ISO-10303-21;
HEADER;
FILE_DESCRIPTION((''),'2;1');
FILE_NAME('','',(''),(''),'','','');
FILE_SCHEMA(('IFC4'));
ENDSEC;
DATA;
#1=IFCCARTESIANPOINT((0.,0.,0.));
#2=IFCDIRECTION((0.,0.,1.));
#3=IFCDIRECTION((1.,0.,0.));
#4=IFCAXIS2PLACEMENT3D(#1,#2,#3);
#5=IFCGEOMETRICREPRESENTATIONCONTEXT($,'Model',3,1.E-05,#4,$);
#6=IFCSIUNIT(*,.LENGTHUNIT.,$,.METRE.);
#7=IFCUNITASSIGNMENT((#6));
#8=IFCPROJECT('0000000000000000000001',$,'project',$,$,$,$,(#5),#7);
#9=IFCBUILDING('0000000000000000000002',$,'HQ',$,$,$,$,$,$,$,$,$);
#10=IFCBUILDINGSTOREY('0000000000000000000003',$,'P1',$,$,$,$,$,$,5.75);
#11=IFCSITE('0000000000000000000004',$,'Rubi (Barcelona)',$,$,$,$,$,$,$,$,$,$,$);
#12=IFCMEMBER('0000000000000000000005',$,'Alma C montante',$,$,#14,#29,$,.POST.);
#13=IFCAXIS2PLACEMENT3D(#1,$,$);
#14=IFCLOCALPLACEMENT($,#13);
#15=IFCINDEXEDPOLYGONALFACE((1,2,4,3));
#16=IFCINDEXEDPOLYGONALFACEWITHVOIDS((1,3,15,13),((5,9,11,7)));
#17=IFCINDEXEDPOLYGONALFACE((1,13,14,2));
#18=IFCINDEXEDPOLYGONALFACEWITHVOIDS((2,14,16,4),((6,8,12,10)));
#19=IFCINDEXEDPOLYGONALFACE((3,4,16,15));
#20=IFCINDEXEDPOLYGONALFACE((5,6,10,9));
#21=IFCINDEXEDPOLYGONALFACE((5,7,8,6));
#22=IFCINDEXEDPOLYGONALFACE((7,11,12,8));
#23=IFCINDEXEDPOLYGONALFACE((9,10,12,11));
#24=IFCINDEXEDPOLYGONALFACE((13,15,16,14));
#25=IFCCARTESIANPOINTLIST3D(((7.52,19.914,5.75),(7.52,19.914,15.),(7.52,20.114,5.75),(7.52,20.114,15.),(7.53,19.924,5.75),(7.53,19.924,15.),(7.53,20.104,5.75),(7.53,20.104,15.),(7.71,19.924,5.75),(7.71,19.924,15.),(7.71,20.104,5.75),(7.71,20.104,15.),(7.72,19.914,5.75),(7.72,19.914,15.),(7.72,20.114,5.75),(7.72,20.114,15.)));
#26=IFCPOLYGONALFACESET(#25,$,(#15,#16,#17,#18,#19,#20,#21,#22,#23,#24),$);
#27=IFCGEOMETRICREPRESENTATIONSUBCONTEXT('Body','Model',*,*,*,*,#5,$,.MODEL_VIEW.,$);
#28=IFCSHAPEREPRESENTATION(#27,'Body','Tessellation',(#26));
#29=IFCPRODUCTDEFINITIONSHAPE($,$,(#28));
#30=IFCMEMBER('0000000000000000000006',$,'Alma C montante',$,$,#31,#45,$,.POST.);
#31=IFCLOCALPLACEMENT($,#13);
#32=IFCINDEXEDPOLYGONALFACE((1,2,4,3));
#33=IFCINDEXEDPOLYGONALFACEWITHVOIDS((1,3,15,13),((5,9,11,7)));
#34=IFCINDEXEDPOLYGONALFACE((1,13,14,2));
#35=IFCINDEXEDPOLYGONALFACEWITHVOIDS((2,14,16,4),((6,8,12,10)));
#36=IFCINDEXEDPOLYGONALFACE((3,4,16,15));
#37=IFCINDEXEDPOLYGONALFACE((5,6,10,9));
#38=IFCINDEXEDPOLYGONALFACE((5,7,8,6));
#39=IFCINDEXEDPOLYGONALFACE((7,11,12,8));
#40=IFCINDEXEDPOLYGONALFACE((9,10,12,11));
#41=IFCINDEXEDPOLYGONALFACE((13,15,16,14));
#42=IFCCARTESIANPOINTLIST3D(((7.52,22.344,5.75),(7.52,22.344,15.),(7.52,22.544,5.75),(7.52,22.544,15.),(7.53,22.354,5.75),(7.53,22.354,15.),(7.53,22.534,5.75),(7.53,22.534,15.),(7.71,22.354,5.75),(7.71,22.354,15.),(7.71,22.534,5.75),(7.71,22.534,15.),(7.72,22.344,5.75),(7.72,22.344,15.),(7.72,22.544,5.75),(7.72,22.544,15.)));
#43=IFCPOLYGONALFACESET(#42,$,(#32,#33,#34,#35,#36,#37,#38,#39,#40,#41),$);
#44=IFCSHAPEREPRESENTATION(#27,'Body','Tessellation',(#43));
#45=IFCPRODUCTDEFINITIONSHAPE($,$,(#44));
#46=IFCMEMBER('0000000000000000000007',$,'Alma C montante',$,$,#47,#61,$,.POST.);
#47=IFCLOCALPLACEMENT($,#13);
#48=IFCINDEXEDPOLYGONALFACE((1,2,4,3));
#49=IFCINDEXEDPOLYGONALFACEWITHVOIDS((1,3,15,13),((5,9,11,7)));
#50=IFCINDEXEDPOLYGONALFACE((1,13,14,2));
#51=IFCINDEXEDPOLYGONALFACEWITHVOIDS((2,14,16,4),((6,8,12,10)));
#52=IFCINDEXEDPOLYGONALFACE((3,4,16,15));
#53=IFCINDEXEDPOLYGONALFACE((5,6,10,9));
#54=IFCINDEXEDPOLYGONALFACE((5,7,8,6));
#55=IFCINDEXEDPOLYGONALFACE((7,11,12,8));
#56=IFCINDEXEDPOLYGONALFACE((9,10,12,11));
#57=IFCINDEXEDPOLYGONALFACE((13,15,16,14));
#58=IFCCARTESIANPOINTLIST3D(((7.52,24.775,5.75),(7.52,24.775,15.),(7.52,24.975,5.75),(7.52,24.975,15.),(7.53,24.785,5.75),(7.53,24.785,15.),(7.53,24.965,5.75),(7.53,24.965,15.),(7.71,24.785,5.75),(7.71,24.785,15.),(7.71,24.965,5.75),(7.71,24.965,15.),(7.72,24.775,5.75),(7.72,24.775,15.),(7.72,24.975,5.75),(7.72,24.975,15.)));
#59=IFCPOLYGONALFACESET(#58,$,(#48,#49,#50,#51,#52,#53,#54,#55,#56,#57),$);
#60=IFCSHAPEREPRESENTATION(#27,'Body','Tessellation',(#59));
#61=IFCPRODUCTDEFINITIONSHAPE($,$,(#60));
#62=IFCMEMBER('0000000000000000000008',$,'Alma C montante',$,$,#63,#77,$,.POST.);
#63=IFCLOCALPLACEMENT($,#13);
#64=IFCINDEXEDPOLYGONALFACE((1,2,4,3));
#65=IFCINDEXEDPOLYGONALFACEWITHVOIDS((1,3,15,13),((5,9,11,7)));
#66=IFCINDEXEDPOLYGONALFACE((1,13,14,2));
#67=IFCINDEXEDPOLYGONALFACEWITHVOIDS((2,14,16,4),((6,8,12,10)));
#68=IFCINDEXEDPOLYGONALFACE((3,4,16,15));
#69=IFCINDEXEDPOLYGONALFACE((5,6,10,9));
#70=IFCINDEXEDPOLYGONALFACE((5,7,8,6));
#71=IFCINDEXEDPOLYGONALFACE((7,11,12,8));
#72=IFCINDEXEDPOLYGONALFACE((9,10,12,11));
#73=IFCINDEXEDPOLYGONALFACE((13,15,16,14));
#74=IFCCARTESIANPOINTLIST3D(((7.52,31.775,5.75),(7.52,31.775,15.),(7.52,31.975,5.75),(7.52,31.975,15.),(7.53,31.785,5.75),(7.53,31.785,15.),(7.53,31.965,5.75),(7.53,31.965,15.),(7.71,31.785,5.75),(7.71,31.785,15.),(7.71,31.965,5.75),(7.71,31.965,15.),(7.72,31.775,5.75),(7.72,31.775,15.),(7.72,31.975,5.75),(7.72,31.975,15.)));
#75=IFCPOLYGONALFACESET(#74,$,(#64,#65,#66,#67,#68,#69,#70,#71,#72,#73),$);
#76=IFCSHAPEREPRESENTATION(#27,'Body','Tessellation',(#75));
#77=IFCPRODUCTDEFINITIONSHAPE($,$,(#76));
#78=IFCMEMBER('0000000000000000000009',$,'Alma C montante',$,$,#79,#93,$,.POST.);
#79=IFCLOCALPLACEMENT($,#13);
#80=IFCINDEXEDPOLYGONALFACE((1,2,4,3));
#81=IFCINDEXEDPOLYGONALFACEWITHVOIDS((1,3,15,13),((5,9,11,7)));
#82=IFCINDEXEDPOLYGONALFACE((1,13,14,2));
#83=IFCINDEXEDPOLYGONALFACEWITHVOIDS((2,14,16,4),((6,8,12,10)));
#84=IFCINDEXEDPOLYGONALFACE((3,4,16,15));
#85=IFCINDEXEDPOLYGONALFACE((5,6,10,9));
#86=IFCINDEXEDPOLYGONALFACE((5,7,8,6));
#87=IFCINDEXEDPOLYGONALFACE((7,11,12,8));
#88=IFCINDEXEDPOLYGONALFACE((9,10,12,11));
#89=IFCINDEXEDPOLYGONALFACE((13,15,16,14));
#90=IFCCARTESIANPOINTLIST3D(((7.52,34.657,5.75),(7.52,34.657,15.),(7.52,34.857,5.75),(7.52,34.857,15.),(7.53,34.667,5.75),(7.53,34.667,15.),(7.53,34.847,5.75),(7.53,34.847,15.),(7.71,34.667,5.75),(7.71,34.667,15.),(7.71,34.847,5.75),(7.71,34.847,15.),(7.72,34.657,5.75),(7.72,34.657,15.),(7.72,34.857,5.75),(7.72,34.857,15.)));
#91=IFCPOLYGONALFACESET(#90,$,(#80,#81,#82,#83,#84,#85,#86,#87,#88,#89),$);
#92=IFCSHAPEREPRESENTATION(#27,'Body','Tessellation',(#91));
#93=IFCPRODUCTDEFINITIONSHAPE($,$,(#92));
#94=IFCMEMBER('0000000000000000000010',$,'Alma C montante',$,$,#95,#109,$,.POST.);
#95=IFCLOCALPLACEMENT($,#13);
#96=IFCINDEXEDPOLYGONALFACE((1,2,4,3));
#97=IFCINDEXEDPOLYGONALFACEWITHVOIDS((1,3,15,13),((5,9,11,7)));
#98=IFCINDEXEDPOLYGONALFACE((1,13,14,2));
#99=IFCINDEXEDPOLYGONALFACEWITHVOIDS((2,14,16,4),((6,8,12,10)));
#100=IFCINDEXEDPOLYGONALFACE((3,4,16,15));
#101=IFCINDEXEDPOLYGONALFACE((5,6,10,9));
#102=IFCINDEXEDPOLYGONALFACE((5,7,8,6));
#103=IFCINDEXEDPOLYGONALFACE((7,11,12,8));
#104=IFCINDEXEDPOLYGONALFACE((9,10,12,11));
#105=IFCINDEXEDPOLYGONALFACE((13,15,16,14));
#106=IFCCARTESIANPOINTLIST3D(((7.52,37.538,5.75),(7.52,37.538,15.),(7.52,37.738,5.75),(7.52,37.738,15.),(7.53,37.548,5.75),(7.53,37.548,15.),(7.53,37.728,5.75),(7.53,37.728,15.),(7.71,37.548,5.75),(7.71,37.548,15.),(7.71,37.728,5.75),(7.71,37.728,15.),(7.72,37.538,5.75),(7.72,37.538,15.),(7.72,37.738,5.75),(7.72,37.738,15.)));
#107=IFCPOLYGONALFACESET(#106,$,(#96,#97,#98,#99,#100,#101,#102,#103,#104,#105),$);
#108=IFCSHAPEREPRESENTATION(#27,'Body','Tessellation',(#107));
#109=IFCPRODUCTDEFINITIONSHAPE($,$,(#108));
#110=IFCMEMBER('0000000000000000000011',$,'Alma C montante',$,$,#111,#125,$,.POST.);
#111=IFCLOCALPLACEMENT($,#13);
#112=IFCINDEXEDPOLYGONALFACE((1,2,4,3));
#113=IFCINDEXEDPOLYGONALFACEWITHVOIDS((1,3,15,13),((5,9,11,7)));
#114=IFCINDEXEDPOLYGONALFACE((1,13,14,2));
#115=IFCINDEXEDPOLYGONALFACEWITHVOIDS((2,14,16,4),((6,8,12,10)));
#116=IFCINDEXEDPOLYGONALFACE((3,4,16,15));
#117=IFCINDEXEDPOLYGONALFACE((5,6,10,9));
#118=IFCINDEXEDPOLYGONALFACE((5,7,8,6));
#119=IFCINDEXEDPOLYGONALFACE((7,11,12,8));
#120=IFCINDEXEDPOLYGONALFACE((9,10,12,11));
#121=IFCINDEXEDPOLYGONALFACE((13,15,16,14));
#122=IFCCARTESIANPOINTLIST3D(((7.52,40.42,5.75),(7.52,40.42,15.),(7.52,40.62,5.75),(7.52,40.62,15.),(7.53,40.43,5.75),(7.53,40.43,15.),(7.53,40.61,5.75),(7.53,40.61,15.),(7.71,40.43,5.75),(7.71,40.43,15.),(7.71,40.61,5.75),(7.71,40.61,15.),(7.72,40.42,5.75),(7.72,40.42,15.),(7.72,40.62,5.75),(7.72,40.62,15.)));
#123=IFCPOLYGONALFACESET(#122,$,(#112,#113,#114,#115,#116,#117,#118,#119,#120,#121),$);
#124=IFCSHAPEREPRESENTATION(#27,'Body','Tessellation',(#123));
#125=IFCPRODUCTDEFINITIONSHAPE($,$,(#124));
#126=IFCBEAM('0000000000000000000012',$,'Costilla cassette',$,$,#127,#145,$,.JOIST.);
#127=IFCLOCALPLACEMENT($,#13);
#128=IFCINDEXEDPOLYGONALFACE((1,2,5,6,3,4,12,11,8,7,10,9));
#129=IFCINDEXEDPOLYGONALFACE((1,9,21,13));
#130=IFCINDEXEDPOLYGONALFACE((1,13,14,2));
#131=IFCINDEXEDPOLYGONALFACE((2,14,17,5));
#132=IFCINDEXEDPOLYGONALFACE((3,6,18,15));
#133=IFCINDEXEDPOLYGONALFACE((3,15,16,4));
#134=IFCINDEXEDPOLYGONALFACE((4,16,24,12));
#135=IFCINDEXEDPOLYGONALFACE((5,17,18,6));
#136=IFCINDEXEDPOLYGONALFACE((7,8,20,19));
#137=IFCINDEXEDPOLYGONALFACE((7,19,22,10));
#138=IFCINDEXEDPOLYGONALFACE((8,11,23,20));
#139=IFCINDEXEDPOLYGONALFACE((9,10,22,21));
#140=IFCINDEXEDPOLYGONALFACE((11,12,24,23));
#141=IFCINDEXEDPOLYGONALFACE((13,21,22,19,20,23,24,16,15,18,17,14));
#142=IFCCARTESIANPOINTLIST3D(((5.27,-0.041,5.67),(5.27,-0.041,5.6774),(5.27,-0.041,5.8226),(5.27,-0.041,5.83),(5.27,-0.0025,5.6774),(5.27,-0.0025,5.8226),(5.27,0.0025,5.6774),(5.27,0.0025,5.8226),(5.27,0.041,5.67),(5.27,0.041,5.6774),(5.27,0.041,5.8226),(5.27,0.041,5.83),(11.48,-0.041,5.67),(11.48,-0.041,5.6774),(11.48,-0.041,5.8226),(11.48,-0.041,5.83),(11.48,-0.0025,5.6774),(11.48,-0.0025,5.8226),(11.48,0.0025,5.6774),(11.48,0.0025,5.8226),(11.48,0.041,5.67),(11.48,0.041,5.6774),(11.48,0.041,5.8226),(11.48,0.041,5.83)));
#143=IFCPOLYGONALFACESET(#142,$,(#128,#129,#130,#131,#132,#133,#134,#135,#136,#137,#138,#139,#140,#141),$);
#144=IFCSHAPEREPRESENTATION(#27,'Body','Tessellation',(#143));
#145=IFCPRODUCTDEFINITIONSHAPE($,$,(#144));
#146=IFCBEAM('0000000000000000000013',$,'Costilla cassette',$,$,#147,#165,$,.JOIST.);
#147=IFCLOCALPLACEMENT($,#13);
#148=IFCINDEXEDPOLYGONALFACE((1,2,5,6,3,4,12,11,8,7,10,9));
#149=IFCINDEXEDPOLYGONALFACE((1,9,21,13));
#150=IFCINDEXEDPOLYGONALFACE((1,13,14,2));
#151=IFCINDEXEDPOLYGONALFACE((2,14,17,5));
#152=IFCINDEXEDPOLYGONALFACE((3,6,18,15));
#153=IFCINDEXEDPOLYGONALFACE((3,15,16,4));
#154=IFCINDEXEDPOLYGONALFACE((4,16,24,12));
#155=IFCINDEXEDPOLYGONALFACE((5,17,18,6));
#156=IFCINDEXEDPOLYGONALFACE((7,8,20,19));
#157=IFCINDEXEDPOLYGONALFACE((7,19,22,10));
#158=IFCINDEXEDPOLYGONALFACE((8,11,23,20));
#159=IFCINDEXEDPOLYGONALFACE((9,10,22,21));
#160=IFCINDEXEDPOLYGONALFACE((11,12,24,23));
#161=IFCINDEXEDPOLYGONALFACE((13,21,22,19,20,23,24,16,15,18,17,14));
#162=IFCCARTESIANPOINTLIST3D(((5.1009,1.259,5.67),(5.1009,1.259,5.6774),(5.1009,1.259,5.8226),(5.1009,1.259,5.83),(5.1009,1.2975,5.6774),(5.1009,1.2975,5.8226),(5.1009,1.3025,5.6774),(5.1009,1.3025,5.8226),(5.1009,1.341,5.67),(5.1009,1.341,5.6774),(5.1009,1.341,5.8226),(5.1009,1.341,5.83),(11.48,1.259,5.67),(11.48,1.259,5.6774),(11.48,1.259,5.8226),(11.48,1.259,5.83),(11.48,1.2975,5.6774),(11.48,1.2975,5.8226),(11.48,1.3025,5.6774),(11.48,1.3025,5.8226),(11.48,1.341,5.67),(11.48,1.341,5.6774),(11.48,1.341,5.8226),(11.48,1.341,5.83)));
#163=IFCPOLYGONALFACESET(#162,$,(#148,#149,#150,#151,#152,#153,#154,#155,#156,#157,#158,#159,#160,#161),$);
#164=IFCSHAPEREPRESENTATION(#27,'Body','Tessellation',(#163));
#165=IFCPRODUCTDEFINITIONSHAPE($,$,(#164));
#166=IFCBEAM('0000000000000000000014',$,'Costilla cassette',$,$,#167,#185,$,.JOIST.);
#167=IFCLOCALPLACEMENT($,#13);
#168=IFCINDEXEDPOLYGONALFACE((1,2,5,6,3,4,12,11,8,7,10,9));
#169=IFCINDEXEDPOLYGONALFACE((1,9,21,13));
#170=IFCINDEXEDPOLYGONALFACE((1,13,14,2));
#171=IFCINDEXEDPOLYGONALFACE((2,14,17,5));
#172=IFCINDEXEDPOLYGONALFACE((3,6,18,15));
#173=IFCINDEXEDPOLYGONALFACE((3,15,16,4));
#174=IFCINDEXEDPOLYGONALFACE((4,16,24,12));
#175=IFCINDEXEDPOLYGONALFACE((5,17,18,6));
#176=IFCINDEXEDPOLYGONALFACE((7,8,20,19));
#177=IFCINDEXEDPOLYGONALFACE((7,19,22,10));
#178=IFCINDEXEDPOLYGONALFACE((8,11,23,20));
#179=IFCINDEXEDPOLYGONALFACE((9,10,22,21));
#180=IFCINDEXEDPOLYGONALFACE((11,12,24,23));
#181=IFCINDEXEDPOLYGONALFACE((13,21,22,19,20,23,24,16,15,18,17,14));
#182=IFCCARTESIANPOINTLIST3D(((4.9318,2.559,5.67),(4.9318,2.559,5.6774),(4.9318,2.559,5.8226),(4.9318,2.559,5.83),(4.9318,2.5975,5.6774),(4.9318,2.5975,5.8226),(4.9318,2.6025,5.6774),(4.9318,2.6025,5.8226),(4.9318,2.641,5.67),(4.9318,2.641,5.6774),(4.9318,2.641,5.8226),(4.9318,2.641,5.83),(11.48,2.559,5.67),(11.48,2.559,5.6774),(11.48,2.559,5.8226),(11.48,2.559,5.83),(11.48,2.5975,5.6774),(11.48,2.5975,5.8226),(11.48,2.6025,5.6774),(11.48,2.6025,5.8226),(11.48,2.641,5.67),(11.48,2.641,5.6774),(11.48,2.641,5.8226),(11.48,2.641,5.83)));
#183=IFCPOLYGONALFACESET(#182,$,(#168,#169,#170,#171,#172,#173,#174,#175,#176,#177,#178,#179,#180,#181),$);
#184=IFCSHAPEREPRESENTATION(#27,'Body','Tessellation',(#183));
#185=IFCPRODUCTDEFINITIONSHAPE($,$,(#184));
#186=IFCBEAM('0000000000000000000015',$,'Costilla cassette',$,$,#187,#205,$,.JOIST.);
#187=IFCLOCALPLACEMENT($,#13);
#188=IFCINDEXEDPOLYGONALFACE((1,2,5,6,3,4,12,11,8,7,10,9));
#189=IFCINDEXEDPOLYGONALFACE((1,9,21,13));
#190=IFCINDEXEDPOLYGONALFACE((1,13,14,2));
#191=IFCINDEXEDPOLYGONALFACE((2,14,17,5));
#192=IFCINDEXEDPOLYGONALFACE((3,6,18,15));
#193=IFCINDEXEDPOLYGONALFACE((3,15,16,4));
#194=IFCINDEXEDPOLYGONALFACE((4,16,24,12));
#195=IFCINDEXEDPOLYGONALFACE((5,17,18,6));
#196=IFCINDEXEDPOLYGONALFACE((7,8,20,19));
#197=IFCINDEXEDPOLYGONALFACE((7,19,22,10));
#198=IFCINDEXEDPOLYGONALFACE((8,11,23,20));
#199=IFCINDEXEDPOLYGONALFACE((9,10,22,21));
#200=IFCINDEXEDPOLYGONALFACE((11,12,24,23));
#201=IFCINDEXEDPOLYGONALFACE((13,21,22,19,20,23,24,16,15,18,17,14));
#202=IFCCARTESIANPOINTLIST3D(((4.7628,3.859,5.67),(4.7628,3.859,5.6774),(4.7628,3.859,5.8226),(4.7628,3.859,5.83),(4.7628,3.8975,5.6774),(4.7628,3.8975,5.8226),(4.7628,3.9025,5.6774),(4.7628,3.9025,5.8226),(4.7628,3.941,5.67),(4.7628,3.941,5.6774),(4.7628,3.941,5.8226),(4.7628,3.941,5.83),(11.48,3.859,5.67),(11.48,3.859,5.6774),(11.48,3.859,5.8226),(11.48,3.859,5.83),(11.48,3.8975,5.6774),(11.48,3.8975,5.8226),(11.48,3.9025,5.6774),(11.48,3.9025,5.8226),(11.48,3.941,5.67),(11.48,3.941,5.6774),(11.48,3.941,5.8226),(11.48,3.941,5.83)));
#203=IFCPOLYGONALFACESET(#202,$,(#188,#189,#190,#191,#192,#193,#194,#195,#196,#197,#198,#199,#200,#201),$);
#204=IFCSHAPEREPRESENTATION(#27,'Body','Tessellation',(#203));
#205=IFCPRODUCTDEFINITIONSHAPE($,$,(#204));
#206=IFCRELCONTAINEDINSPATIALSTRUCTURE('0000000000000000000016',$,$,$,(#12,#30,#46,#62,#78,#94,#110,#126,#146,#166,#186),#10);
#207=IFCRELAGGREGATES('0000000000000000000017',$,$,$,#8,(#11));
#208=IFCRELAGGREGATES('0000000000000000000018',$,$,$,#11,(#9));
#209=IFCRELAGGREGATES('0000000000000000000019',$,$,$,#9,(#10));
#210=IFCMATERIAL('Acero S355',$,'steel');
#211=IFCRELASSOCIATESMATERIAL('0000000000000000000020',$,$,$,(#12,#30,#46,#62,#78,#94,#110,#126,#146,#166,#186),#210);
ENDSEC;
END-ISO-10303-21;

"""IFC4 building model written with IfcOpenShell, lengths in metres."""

from ifc_helpers import new_model, si_unit, frame, origin_with_axes, place, context, subcontext, project, spatial, hollow_rectangle, i_section, extrude, material, element, save


model = new_model("IFC4")

# Units and contexts
model_context = context("Model", 3, precision=1e-05, world=origin_with_axes())
body_context = subcontext(model_context, "Body", "Model", "MODEL_VIEW")
ifc_project = project(units=[si_unit("LENGTHUNIT", "METRE")], contexts=[model_context])

# Site, building, storey
site = spatial("IfcSite", under=ifc_project, Name="Rubi (Barcelona)")
building = spatial("IfcBuilding", under=site, Name="HQ")
storey = spatial("IfcBuildingStorey", under=building, Name="P1", Elevation=5.75)

# Members
ifc_material = material(Name="Acero S355", Category="steel")
member_1_placement = place(None, origin_with_axes())
element("IfcMember", 1, at=member_1_placement, inside=storey, material=ifc_material, Name="Alma C montante", PredefinedType="POST", context=body_context, shape_type="SweptSolid", body=[
    extrude(hollow_rectangle(XDim=0.2, YDim=0.2, WallThickness=0.01), frame((7.62, 20.014, 5.75), z_axis=(0.0, 0.0, 1.0), x_axis=(1.0, 0.0, 0.0)), (0.0, 0.0, 1.0), 9.25),
])
member_2_placement = place(None, origin_with_axes())
element("IfcMember", 2, at=member_2_placement, inside=storey, material=ifc_material, Name="Alma C montante", PredefinedType="POST", context=body_context, shape_type="SweptSolid", body=[
    extrude(hollow_rectangle(XDim=0.2, YDim=0.2, WallThickness=0.01), frame((7.62, 22.444, 5.75), z_axis=(0.0, 0.0, 1.0), x_axis=(1.0, 0.0, 0.0)), (0.0, 0.0, 1.0), 9.25),
])
member_3_placement = place(None, origin_with_axes())
element("IfcMember", 3, at=member_3_placement, inside=storey, material=ifc_material, Name="Alma C montante", PredefinedType="POST", context=body_context, shape_type="SweptSolid", body=[
    extrude(hollow_rectangle(XDim=0.2, YDim=0.2, WallThickness=0.01), frame((7.62, 24.875, 5.75), z_axis=(0.0, 0.0, 1.0), x_axis=(1.0, 0.0, 0.0)), (0.0, 0.0, 1.0), 9.25),
])
member_4_placement = place(None, origin_with_axes())
element("IfcMember", 4, at=member_4_placement, inside=storey, material=ifc_material, Name="Alma C montante", PredefinedType="POST", context=body_context, shape_type="SweptSolid", body=[
    extrude(hollow_rectangle(XDim=0.2, YDim=0.2, WallThickness=0.01), frame((7.62, 31.875, 5.75), z_axis=(0.0, 0.0, 1.0), x_axis=(1.0, 0.0, 0.0)), (0.0, 0.0, 1.0), 9.25),
])
member_5_placement = place(None, origin_with_axes())
element("IfcMember", 5, at=member_5_placement, inside=storey, material=ifc_material, Name="Alma C montante", PredefinedType="POST", context=body_context, shape_type="SweptSolid", body=[
    extrude(hollow_rectangle(XDim=0.2, YDim=0.2, WallThickness=0.01), frame((7.62, 34.757, 5.75), z_axis=(0.0, 0.0, 1.0), x_axis=(1.0, 0.0, 0.0)), (0.0, 0.0, 1.0), 9.25),
])
member_6_placement = place(None, origin_with_axes())
element("IfcMember", 6, at=member_6_placement, inside=storey, material=ifc_material, Name="Alma C montante", PredefinedType="POST", context=body_context, shape_type="SweptSolid", body=[
    extrude(hollow_rectangle(XDim=0.2, YDim=0.2, WallThickness=0.01), frame((7.62, 37.638, 5.75), z_axis=(0.0, 0.0, 1.0), x_axis=(1.0, 0.0, 0.0)), (0.0, 0.0, 1.0), 9.25),
])
member_7_placement = place(None, origin_with_axes())
element("IfcMember", 7, at=member_7_placement, inside=storey, material=ifc_material, Name="Alma C montante", PredefinedType="POST", context=body_context, shape_type="SweptSolid", body=[
    extrude(hollow_rectangle(XDim=0.2, YDim=0.2, WallThickness=0.01), frame((7.62, 40.52, 5.75), z_axis=(0.0, 0.0, 1.0), x_axis=(1.0, 0.0, 0.0)), (0.0, 0.0, 1.0), 9.25),
])

# Beams
beam_1_placement = place(None, origin_with_axes())
element("IfcBeam", 8, at=beam_1_placement, inside=storey, material=ifc_material, Name="Costilla cassette", PredefinedType="JOIST", context=body_context, shape_type="SweptSolid", body=[
    extrude(i_section(OverallWidth=0.082, OverallDepth=0.16, WebThickness=0.005, FlangeThickness=0.0074), frame((5.27, 0.0, 5.75), z_axis=(1.0, 0.0, 0.0), x_axis=(0.0, 1.0, 0.0)), (0.0, 0.0, 1.0), 6.21),
])
beam_2_placement = place(None, origin_with_axes())
element("IfcBeam", 9, at=beam_2_placement, inside=storey, material=ifc_material, Name="Costilla cassette", PredefinedType="JOIST", context=body_context, shape_type="SweptSolid", body=[
    extrude(i_section(OverallWidth=0.082, OverallDepth=0.16, WebThickness=0.005, FlangeThickness=0.0074), frame((5.1009, 1.3, 5.75), z_axis=(1.0, 0.0, 0.0), x_axis=(0.0, 1.0, 0.0)), (0.0, 0.0, 1.0), 6.3791),
])
beam_3_placement = place(None, origin_with_axes())
element("IfcBeam", 10, at=beam_3_placement, inside=storey, material=ifc_material, Name="Costilla cassette", PredefinedType="JOIST", context=body_context, shape_type="SweptSolid", body=[
    extrude(i_section(OverallWidth=0.082, OverallDepth=0.16, WebThickness=0.005, FlangeThickness=0.0074), frame((4.9318, 2.6, 5.75), z_axis=(1.0, 0.0, 0.0), x_axis=(0.0, 1.0, 0.0)), (0.0, 0.0, 1.0), 6.5482),
])
beam_4_placement = place(None, origin_with_axes())
element("IfcBeam", 11, at=beam_4_placement, inside=storey, material=ifc_material, Name="Costilla cassette", PredefinedType="JOIST", context=body_context, shape_type="SweptSolid", body=[
    extrude(i_section(OverallWidth=0.082, OverallDepth=0.16, WebThickness=0.005, FlangeThickness=0.0074), frame((4.7628, 3.9, 5.75), z_axis=(1.0, 0.0, 0.0), x_axis=(0.0, 1.0, 0.0)), (0.0, 0.0, 1.0), 6.7172),
])

save(model, "model.ifc")
